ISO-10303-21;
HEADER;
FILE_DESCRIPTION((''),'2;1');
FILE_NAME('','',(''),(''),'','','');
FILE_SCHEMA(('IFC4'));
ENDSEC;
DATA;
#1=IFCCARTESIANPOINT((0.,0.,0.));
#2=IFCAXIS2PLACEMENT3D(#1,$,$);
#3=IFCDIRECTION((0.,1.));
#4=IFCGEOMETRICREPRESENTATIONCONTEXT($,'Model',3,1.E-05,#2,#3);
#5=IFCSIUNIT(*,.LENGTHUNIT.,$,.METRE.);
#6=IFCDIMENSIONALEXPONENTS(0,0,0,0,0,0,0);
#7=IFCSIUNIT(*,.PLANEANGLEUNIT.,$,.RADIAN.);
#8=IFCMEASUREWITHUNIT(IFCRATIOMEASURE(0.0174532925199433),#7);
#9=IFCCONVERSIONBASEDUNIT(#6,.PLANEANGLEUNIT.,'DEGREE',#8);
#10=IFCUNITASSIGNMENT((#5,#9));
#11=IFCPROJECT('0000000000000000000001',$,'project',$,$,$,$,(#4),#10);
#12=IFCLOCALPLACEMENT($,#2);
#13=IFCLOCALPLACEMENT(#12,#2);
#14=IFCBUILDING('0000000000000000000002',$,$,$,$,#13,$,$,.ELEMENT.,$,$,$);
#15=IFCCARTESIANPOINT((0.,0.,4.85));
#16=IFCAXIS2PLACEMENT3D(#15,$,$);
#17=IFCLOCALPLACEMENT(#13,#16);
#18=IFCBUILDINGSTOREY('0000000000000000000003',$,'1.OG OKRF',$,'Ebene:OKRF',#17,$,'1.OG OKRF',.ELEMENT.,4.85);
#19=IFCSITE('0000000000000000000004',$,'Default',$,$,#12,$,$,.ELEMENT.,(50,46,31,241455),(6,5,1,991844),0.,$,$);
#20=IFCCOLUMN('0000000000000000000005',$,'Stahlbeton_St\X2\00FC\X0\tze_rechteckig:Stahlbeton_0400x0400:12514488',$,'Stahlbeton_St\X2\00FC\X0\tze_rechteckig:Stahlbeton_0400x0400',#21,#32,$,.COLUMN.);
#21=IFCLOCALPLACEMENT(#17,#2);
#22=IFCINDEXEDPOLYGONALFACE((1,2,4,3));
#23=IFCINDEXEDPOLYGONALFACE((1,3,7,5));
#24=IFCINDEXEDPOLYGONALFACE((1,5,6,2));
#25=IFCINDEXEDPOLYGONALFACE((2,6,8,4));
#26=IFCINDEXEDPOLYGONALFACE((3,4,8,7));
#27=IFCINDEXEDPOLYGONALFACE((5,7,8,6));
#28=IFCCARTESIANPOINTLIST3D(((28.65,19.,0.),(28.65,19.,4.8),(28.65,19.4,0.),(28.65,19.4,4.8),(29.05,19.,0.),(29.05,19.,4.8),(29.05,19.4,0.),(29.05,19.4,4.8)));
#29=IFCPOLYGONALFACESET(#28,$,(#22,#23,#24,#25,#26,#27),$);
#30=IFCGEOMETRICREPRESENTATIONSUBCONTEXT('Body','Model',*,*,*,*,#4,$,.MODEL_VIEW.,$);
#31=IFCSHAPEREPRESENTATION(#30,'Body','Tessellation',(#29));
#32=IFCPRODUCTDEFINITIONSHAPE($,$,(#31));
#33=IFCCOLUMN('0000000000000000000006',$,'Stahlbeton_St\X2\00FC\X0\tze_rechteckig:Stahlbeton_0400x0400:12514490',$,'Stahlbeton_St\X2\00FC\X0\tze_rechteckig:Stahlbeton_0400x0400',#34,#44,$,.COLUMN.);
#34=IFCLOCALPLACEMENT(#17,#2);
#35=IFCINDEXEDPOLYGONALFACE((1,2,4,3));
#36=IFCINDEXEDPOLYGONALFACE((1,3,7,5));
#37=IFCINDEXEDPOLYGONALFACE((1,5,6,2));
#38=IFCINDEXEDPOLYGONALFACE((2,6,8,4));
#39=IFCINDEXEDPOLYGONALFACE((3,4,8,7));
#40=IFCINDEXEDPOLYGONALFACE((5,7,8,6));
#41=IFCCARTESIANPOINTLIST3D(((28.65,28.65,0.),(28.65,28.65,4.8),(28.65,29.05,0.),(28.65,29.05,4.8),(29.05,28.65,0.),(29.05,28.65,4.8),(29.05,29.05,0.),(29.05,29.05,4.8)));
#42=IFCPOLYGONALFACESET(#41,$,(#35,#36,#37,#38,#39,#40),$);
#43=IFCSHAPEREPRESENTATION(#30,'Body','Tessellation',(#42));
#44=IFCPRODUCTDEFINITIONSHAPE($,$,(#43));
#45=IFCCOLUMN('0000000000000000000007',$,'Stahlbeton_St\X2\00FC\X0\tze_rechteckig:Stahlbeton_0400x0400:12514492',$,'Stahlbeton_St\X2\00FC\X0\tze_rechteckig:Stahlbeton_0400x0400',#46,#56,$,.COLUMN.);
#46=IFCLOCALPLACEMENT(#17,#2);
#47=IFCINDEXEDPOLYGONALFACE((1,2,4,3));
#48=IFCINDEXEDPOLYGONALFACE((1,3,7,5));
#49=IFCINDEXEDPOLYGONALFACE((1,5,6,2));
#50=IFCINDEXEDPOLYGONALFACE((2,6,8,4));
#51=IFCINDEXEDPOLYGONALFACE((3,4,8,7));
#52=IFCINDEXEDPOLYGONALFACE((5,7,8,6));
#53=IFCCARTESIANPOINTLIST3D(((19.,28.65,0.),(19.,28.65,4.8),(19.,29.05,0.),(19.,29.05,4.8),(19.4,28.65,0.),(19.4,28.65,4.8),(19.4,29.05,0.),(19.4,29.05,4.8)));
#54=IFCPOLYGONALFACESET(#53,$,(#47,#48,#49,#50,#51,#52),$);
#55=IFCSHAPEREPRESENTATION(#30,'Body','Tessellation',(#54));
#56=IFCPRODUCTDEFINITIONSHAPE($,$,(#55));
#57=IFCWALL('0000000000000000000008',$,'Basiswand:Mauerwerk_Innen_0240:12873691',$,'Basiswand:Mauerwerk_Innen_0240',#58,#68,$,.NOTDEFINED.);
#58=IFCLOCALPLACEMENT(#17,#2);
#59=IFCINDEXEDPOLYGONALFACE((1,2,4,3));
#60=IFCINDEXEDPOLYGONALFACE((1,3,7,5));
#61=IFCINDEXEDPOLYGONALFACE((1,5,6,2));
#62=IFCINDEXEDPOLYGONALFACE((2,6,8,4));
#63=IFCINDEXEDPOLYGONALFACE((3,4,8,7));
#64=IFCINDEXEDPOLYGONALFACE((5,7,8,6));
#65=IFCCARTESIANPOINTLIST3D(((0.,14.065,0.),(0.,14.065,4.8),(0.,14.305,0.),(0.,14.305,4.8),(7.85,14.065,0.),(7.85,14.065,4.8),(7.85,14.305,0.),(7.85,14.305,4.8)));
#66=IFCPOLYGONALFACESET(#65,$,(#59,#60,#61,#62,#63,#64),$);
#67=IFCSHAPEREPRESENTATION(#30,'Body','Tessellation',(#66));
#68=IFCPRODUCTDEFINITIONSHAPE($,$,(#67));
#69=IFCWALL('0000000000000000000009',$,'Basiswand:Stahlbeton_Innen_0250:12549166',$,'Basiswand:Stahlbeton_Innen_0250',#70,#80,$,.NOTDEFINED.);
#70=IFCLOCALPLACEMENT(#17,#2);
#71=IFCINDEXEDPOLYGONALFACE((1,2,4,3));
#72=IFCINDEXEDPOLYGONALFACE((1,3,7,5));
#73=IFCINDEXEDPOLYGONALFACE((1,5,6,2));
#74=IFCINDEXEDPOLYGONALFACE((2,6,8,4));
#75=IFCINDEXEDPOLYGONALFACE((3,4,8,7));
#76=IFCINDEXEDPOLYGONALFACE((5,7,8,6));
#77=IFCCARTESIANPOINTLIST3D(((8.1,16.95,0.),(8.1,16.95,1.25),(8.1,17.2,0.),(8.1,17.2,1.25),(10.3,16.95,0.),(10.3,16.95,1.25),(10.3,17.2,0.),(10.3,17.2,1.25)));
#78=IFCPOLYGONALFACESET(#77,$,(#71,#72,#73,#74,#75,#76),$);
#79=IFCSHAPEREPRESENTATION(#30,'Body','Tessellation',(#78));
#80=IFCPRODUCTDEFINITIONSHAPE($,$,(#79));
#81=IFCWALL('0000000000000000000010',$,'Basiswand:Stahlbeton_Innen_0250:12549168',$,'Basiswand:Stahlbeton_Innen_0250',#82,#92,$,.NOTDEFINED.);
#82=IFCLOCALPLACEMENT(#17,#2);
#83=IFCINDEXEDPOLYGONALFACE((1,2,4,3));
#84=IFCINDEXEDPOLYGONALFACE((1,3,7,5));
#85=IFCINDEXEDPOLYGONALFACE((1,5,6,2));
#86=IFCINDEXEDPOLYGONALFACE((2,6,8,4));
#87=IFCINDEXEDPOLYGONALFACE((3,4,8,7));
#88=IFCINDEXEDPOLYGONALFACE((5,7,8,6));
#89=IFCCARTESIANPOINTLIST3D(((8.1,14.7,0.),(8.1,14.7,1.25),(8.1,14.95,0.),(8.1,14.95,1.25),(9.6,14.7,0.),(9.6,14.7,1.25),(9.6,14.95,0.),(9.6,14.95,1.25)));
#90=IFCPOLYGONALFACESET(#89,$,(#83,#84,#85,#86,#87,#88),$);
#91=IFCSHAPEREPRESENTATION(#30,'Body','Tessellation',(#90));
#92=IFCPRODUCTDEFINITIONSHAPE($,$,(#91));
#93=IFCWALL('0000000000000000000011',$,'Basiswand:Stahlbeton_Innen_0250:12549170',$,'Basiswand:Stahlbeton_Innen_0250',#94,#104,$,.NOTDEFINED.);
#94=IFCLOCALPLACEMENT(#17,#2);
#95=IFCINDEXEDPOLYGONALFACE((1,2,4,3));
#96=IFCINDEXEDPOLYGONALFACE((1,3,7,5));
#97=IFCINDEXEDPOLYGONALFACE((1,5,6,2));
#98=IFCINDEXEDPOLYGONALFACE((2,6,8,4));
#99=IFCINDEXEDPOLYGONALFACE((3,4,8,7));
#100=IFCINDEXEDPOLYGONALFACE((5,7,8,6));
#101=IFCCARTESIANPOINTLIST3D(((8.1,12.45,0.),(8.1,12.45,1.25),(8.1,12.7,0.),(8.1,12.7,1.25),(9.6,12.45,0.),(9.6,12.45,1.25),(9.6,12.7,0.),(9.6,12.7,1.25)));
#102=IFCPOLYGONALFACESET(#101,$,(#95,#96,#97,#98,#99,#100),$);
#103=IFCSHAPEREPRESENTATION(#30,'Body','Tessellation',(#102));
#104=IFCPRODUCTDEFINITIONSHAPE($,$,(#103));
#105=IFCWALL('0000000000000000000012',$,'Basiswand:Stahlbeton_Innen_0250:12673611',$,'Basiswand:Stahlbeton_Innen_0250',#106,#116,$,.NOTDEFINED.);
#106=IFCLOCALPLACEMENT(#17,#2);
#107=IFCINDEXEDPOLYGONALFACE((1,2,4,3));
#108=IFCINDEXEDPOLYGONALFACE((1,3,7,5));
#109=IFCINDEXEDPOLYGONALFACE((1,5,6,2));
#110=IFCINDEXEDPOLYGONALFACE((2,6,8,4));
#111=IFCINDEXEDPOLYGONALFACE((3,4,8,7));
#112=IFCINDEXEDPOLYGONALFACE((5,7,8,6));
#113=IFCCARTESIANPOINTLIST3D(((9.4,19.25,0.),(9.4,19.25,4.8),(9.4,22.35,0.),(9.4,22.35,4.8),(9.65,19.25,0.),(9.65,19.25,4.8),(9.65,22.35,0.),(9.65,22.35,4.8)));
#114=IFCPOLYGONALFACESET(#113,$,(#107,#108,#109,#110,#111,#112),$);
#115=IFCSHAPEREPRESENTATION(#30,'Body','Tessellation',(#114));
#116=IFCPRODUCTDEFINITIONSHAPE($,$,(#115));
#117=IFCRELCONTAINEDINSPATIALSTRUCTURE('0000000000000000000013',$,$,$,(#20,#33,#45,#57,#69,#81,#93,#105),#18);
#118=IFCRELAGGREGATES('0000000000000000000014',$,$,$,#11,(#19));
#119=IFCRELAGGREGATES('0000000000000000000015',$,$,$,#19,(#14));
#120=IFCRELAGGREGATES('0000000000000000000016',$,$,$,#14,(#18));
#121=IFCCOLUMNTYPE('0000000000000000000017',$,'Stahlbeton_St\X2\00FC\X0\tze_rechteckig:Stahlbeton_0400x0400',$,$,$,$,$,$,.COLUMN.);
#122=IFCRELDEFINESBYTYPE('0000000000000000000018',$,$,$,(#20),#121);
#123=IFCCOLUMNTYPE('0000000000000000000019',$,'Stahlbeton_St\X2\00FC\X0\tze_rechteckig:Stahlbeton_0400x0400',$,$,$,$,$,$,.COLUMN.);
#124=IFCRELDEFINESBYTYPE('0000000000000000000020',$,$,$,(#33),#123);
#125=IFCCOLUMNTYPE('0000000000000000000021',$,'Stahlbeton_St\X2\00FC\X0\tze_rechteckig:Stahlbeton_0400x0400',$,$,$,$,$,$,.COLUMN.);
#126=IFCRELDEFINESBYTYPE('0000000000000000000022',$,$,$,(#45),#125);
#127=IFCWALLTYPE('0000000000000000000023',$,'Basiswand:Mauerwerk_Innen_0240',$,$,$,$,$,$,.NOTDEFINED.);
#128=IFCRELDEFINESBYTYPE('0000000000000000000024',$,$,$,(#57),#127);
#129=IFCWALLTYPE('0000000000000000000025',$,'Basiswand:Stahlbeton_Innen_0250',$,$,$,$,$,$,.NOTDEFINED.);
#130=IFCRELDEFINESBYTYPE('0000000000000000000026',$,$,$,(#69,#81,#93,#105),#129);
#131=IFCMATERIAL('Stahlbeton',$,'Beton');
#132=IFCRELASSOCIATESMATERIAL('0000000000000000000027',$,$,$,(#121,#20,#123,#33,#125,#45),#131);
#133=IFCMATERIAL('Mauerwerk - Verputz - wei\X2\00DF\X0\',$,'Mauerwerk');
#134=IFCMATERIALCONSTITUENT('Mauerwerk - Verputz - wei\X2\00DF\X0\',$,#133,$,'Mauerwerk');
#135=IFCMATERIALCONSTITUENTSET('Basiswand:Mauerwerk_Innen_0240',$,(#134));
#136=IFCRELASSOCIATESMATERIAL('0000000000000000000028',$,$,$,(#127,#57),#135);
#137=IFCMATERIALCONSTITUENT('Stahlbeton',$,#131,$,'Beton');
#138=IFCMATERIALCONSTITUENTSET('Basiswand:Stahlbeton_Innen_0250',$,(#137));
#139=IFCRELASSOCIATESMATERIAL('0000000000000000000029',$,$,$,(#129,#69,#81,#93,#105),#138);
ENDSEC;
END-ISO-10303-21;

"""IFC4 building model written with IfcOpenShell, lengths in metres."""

from ifc_helpers import new_model, entity, si_unit, converted_unit, direction, frame, origin, place, context, subcontext, project, spatial, indexed_curve, outline, extrude, source, transform, mapped, material, constituent, constituent_set, type_object, type_shapes, element, save


model = new_model("IFC4")

# Units and contexts
model_context = context("Model", 3, precision=1e-05, world=origin(), true_north=direction((0.0, 1.0)))
body_context = subcontext(model_context, "Body", "Model", "MODEL_VIEW")
ifc_project = project(units=[si_unit("LENGTHUNIT", "METRE"), converted_unit("PLANEANGLEUNIT", "DEGREE", entity("IfcRatioMeasure", 0.0174532925199433), si_unit("PLANEANGLEUNIT", "RADIAN"), dimensions=[0, 0, 0, 0, 0, 0, 0])], contexts=[model_context])

# Site, building, storey
site_placement = place(None, origin())
site = spatial("IfcSite", under=ifc_project, at=site_placement, Name="Default", CompositionType="ELEMENT", RefLatitude=(50, 46, 31, 241455), RefLongitude=(6, 5, 1, 991844), RefElevation=0.0)
building_placement = place(site_placement, origin())
building = spatial("IfcBuilding", under=site, at=building_placement, CompositionType="ELEMENT")
storey_placement = place(building_placement, frame((0.0, 0.0, 4.85)))
storey = spatial("IfcBuildingStorey", under=building, at=storey_placement, Name="1.OG OKRF", ObjectType="Ebene:OKRF", LongName="1.OG OKRF", CompositionType="ELEMENT", Elevation=4.85)

# Columns
ifc_material_1 = material(Name="Stahlbeton", Category="Beton")
column_type_1 = type_object("IfcColumnType", Name="Stahlbeton_Stütze_rechteckig:Stahlbeton_0400x0400", PredefinedType="COLUMN", material=ifc_material_1)
shared_shape_1 = source(origin(), body_context, "Body", "SweptSolid", [
    extrude(outline(indexed_curve([(-0.2, -0.2), (0.2, -0.2), (0.2, 0.2), (-0.2, 0.2), (-0.2, -0.2)], self_intersect=False)), frame((28.85, 19.2, 4.85), z_axis=(0.0, 0.0, 1.0), x_axis=(0.0, -1.0, 0.0)), (0.0, 0.0, 1.0), 4.8),
])
type_shapes(column_type_1, [shared_shape_1])
column_1_placement = place(storey_placement, frame((0.0, 0.0, -4.85)))
element("IfcColumn", 1, at=column_1_placement, inside=storey, type_object=column_type_1, material=ifc_material_1, Name="Stahlbeton_Stütze_rechteckig:Stahlbeton_0400x0400:12514488", ObjectType="Stahlbeton_Stütze_rechteckig:Stahlbeton_0400x0400", PredefinedType="COLUMN", context=body_context, shape_type="MappedRepresentation", body=[
    mapped(shared_shape_1, transform((0.0, 0.0, 0.0), scale=1.0)),
])
column_type_2 = type_object("IfcColumnType", Name="Stahlbeton_Stütze_rechteckig:Stahlbeton_0400x0400", PredefinedType="COLUMN", material=ifc_material_1)
shared_shape_2 = source(origin(), body_context, "Body", "SweptSolid", [
    extrude(outline(indexed_curve([(-0.2, -0.2), (0.2, -0.2), (0.2, 0.2), (-0.2, 0.2), (-0.2, -0.2)], self_intersect=False)), frame((28.85, 28.85, 4.85), z_axis=(0.0, 0.0, 1.0), x_axis=(0.0, -1.0, 0.0)), (0.0, 0.0, 1.0), 4.8),
])
type_shapes(column_type_2, [shared_shape_2])
column_2_placement = place(storey_placement, frame((0.0, 0.0, -4.85)))
element("IfcColumn", 2, at=column_2_placement, inside=storey, type_object=column_type_2, material=ifc_material_1, Name="Stahlbeton_Stütze_rechteckig:Stahlbeton_0400x0400:12514490", ObjectType="Stahlbeton_Stütze_rechteckig:Stahlbeton_0400x0400", PredefinedType="COLUMN", context=body_context, shape_type="MappedRepresentation", body=[
    mapped(shared_shape_2, transform((0.0, 0.0, 0.0), scale=1.0)),
])
column_type_3 = type_object("IfcColumnType", Name="Stahlbeton_Stütze_rechteckig:Stahlbeton_0400x0400", PredefinedType="COLUMN", material=ifc_material_1)
shared_shape_3 = source(origin(), body_context, "Body", "SweptSolid", [
    extrude(outline(indexed_curve([(-0.2, -0.2), (0.2, -0.2), (0.2, 0.2), (-0.2, 0.2), (-0.2, -0.2)], self_intersect=False)), frame((19.2, 28.85, 4.85), z_axis=(0.0, 0.0, 1.0), x_axis=(0.0, -1.0, 0.0)), (0.0, 0.0, 1.0), 4.8),
])
type_shapes(column_type_3, [shared_shape_3])
column_3_placement = place(storey_placement, frame((0.0, 0.0, -4.85)))
element("IfcColumn", 3, at=column_3_placement, inside=storey, type_object=column_type_3, material=ifc_material_1, Name="Stahlbeton_Stütze_rechteckig:Stahlbeton_0400x0400:12514492", ObjectType="Stahlbeton_Stütze_rechteckig:Stahlbeton_0400x0400", PredefinedType="COLUMN", context=body_context, shape_type="MappedRepresentation", body=[
    mapped(shared_shape_3, transform((0.0, 0.0, 0.0), scale=1.0)),
])

# Walls
ifc_material_2 = material(Name="Mauerwerk - Verputz - weiß", Category="Mauerwerk")
ifc_constituent_1 = constituent(ifc_material_2, Name="Mauerwerk - Verputz - weiß", Category="Mauerwerk")
ifc_constituent_set_1 = constituent_set(constituents=[ifc_constituent_1], Name="Basiswand:Mauerwerk_Innen_0240")
wall_type_1 = type_object("IfcWallType", Name="Basiswand:Mauerwerk_Innen_0240", PredefinedType="NOTDEFINED", material=ifc_constituent_set_1)
wall_1_placement = place(storey_placement, frame((0.0, 14.185, 0.0)))
element("IfcWall", 4, at=wall_1_placement, inside=storey, type_object=wall_type_1, material=ifc_constituent_set_1, Name="Basiswand:Mauerwerk_Innen_0240:12873691", ObjectType="Basiswand:Mauerwerk_Innen_0240", PredefinedType="NOTDEFINED", context=body_context, shape_type="SweptSolid", body=[
    extrude(outline(indexed_curve([(-0.12, -3.925), (0.12, -3.925), (0.12, 3.925), (-0.12, 3.925), (-0.12, -3.925)], self_intersect=False)), frame((3.925, 0.0, 0.0), z_axis=(0.0, 0.0, 1.0), x_axis=(0.0, 1.0, 0.0)), (0.0, 0.0, 1.0), 4.8),
])
ifc_constituent_2 = constituent(ifc_material_1, Name="Stahlbeton", Category="Beton")
ifc_constituent_set_2 = constituent_set(constituents=[ifc_constituent_2], Name="Basiswand:Stahlbeton_Innen_0250")
wall_type_2 = type_object("IfcWallType", Name="Basiswand:Stahlbeton_Innen_0250", PredefinedType="NOTDEFINED", material=ifc_constituent_set_2)
wall_2_placement = place(storey_placement, frame((8.1, 17.075, 0.0)))
element("IfcWall", 5, at=wall_2_placement, inside=storey, type_object=wall_type_2, material=ifc_constituent_set_2, Name="Basiswand:Stahlbeton_Innen_0250:12549166", ObjectType="Basiswand:Stahlbeton_Innen_0250", PredefinedType="NOTDEFINED", context=body_context, shape_type="SweptSolid", body=[
    extrude(outline(indexed_curve([(-0.125, -1.1), (0.125, -1.1), (0.125, 1.1), (-0.125, 1.1), (-0.125, -1.1)], self_intersect=False)), frame((1.1, 0.0, 0.0), z_axis=(0.0, 0.0, 1.0), x_axis=(0.0, 1.0, 0.0)), (0.0, 0.0, 1.0), 1.25),
])
wall_3_placement = place(storey_placement, frame((8.1, 14.825, 0.0)))
element("IfcWall", 6, at=wall_3_placement, inside=storey, type_object=wall_type_2, material=ifc_constituent_set_2, Name="Basiswand:Stahlbeton_Innen_0250:12549168", ObjectType="Basiswand:Stahlbeton_Innen_0250", PredefinedType="NOTDEFINED", context=body_context, shape_type="SweptSolid", body=[
    extrude(outline(indexed_curve([(-0.125, -0.75), (0.125, -0.75), (0.125, 0.75), (-0.125, 0.75), (-0.125, -0.75)], self_intersect=False)), frame((0.75, 0.0, 0.0), z_axis=(0.0, 0.0, 1.0), x_axis=(0.0, 1.0, 0.0)), (0.0, 0.0, 1.0), 1.25),
])
wall_4_placement = place(storey_placement, frame((8.1, 12.575, 0.0)))
element("IfcWall", 7, at=wall_4_placement, inside=storey, type_object=wall_type_2, material=ifc_constituent_set_2, Name="Basiswand:Stahlbeton_Innen_0250:12549170", ObjectType="Basiswand:Stahlbeton_Innen_0250", PredefinedType="NOTDEFINED", context=body_context, shape_type="SweptSolid", body=[
    extrude(outline(indexed_curve([(-0.125, -0.75), (0.125, -0.75), (0.125, 0.75), (-0.125, 0.75), (-0.125, -0.75)], self_intersect=False)), frame((0.75, 0.0, 0.0), z_axis=(0.0, 0.0, 1.0), x_axis=(0.0, 1.0, 0.0)), (0.0, 0.0, 1.0), 1.25),
])
wall_5_placement = place(storey_placement, frame((9.525, 22.35, 0.0), z_axis=(0.0, 0.0, 1.0), x_axis=(0.0, -1.0, 0.0)))
element("IfcWall", 8, at=wall_5_placement, inside=storey, type_object=wall_type_2, material=ifc_constituent_set_2, Name="Basiswand:Stahlbeton_Innen_0250:12673611", ObjectType="Basiswand:Stahlbeton_Innen_0250", PredefinedType="NOTDEFINED", context=body_context, shape_type="SweptSolid", body=[
    extrude(outline(indexed_curve([(-0.125, -1.55), (0.125, -1.55), (0.125, 1.55), (-0.125, 1.55), (-0.125, -1.55)], self_intersect=False)), frame((1.55, 0.0, 0.0), z_axis=(0.0, 0.0, 1.0), x_axis=(0.0, 1.0, 0.0)), (0.0, 0.0, 1.0), 4.8),
])

save(model, "model.ifc")
